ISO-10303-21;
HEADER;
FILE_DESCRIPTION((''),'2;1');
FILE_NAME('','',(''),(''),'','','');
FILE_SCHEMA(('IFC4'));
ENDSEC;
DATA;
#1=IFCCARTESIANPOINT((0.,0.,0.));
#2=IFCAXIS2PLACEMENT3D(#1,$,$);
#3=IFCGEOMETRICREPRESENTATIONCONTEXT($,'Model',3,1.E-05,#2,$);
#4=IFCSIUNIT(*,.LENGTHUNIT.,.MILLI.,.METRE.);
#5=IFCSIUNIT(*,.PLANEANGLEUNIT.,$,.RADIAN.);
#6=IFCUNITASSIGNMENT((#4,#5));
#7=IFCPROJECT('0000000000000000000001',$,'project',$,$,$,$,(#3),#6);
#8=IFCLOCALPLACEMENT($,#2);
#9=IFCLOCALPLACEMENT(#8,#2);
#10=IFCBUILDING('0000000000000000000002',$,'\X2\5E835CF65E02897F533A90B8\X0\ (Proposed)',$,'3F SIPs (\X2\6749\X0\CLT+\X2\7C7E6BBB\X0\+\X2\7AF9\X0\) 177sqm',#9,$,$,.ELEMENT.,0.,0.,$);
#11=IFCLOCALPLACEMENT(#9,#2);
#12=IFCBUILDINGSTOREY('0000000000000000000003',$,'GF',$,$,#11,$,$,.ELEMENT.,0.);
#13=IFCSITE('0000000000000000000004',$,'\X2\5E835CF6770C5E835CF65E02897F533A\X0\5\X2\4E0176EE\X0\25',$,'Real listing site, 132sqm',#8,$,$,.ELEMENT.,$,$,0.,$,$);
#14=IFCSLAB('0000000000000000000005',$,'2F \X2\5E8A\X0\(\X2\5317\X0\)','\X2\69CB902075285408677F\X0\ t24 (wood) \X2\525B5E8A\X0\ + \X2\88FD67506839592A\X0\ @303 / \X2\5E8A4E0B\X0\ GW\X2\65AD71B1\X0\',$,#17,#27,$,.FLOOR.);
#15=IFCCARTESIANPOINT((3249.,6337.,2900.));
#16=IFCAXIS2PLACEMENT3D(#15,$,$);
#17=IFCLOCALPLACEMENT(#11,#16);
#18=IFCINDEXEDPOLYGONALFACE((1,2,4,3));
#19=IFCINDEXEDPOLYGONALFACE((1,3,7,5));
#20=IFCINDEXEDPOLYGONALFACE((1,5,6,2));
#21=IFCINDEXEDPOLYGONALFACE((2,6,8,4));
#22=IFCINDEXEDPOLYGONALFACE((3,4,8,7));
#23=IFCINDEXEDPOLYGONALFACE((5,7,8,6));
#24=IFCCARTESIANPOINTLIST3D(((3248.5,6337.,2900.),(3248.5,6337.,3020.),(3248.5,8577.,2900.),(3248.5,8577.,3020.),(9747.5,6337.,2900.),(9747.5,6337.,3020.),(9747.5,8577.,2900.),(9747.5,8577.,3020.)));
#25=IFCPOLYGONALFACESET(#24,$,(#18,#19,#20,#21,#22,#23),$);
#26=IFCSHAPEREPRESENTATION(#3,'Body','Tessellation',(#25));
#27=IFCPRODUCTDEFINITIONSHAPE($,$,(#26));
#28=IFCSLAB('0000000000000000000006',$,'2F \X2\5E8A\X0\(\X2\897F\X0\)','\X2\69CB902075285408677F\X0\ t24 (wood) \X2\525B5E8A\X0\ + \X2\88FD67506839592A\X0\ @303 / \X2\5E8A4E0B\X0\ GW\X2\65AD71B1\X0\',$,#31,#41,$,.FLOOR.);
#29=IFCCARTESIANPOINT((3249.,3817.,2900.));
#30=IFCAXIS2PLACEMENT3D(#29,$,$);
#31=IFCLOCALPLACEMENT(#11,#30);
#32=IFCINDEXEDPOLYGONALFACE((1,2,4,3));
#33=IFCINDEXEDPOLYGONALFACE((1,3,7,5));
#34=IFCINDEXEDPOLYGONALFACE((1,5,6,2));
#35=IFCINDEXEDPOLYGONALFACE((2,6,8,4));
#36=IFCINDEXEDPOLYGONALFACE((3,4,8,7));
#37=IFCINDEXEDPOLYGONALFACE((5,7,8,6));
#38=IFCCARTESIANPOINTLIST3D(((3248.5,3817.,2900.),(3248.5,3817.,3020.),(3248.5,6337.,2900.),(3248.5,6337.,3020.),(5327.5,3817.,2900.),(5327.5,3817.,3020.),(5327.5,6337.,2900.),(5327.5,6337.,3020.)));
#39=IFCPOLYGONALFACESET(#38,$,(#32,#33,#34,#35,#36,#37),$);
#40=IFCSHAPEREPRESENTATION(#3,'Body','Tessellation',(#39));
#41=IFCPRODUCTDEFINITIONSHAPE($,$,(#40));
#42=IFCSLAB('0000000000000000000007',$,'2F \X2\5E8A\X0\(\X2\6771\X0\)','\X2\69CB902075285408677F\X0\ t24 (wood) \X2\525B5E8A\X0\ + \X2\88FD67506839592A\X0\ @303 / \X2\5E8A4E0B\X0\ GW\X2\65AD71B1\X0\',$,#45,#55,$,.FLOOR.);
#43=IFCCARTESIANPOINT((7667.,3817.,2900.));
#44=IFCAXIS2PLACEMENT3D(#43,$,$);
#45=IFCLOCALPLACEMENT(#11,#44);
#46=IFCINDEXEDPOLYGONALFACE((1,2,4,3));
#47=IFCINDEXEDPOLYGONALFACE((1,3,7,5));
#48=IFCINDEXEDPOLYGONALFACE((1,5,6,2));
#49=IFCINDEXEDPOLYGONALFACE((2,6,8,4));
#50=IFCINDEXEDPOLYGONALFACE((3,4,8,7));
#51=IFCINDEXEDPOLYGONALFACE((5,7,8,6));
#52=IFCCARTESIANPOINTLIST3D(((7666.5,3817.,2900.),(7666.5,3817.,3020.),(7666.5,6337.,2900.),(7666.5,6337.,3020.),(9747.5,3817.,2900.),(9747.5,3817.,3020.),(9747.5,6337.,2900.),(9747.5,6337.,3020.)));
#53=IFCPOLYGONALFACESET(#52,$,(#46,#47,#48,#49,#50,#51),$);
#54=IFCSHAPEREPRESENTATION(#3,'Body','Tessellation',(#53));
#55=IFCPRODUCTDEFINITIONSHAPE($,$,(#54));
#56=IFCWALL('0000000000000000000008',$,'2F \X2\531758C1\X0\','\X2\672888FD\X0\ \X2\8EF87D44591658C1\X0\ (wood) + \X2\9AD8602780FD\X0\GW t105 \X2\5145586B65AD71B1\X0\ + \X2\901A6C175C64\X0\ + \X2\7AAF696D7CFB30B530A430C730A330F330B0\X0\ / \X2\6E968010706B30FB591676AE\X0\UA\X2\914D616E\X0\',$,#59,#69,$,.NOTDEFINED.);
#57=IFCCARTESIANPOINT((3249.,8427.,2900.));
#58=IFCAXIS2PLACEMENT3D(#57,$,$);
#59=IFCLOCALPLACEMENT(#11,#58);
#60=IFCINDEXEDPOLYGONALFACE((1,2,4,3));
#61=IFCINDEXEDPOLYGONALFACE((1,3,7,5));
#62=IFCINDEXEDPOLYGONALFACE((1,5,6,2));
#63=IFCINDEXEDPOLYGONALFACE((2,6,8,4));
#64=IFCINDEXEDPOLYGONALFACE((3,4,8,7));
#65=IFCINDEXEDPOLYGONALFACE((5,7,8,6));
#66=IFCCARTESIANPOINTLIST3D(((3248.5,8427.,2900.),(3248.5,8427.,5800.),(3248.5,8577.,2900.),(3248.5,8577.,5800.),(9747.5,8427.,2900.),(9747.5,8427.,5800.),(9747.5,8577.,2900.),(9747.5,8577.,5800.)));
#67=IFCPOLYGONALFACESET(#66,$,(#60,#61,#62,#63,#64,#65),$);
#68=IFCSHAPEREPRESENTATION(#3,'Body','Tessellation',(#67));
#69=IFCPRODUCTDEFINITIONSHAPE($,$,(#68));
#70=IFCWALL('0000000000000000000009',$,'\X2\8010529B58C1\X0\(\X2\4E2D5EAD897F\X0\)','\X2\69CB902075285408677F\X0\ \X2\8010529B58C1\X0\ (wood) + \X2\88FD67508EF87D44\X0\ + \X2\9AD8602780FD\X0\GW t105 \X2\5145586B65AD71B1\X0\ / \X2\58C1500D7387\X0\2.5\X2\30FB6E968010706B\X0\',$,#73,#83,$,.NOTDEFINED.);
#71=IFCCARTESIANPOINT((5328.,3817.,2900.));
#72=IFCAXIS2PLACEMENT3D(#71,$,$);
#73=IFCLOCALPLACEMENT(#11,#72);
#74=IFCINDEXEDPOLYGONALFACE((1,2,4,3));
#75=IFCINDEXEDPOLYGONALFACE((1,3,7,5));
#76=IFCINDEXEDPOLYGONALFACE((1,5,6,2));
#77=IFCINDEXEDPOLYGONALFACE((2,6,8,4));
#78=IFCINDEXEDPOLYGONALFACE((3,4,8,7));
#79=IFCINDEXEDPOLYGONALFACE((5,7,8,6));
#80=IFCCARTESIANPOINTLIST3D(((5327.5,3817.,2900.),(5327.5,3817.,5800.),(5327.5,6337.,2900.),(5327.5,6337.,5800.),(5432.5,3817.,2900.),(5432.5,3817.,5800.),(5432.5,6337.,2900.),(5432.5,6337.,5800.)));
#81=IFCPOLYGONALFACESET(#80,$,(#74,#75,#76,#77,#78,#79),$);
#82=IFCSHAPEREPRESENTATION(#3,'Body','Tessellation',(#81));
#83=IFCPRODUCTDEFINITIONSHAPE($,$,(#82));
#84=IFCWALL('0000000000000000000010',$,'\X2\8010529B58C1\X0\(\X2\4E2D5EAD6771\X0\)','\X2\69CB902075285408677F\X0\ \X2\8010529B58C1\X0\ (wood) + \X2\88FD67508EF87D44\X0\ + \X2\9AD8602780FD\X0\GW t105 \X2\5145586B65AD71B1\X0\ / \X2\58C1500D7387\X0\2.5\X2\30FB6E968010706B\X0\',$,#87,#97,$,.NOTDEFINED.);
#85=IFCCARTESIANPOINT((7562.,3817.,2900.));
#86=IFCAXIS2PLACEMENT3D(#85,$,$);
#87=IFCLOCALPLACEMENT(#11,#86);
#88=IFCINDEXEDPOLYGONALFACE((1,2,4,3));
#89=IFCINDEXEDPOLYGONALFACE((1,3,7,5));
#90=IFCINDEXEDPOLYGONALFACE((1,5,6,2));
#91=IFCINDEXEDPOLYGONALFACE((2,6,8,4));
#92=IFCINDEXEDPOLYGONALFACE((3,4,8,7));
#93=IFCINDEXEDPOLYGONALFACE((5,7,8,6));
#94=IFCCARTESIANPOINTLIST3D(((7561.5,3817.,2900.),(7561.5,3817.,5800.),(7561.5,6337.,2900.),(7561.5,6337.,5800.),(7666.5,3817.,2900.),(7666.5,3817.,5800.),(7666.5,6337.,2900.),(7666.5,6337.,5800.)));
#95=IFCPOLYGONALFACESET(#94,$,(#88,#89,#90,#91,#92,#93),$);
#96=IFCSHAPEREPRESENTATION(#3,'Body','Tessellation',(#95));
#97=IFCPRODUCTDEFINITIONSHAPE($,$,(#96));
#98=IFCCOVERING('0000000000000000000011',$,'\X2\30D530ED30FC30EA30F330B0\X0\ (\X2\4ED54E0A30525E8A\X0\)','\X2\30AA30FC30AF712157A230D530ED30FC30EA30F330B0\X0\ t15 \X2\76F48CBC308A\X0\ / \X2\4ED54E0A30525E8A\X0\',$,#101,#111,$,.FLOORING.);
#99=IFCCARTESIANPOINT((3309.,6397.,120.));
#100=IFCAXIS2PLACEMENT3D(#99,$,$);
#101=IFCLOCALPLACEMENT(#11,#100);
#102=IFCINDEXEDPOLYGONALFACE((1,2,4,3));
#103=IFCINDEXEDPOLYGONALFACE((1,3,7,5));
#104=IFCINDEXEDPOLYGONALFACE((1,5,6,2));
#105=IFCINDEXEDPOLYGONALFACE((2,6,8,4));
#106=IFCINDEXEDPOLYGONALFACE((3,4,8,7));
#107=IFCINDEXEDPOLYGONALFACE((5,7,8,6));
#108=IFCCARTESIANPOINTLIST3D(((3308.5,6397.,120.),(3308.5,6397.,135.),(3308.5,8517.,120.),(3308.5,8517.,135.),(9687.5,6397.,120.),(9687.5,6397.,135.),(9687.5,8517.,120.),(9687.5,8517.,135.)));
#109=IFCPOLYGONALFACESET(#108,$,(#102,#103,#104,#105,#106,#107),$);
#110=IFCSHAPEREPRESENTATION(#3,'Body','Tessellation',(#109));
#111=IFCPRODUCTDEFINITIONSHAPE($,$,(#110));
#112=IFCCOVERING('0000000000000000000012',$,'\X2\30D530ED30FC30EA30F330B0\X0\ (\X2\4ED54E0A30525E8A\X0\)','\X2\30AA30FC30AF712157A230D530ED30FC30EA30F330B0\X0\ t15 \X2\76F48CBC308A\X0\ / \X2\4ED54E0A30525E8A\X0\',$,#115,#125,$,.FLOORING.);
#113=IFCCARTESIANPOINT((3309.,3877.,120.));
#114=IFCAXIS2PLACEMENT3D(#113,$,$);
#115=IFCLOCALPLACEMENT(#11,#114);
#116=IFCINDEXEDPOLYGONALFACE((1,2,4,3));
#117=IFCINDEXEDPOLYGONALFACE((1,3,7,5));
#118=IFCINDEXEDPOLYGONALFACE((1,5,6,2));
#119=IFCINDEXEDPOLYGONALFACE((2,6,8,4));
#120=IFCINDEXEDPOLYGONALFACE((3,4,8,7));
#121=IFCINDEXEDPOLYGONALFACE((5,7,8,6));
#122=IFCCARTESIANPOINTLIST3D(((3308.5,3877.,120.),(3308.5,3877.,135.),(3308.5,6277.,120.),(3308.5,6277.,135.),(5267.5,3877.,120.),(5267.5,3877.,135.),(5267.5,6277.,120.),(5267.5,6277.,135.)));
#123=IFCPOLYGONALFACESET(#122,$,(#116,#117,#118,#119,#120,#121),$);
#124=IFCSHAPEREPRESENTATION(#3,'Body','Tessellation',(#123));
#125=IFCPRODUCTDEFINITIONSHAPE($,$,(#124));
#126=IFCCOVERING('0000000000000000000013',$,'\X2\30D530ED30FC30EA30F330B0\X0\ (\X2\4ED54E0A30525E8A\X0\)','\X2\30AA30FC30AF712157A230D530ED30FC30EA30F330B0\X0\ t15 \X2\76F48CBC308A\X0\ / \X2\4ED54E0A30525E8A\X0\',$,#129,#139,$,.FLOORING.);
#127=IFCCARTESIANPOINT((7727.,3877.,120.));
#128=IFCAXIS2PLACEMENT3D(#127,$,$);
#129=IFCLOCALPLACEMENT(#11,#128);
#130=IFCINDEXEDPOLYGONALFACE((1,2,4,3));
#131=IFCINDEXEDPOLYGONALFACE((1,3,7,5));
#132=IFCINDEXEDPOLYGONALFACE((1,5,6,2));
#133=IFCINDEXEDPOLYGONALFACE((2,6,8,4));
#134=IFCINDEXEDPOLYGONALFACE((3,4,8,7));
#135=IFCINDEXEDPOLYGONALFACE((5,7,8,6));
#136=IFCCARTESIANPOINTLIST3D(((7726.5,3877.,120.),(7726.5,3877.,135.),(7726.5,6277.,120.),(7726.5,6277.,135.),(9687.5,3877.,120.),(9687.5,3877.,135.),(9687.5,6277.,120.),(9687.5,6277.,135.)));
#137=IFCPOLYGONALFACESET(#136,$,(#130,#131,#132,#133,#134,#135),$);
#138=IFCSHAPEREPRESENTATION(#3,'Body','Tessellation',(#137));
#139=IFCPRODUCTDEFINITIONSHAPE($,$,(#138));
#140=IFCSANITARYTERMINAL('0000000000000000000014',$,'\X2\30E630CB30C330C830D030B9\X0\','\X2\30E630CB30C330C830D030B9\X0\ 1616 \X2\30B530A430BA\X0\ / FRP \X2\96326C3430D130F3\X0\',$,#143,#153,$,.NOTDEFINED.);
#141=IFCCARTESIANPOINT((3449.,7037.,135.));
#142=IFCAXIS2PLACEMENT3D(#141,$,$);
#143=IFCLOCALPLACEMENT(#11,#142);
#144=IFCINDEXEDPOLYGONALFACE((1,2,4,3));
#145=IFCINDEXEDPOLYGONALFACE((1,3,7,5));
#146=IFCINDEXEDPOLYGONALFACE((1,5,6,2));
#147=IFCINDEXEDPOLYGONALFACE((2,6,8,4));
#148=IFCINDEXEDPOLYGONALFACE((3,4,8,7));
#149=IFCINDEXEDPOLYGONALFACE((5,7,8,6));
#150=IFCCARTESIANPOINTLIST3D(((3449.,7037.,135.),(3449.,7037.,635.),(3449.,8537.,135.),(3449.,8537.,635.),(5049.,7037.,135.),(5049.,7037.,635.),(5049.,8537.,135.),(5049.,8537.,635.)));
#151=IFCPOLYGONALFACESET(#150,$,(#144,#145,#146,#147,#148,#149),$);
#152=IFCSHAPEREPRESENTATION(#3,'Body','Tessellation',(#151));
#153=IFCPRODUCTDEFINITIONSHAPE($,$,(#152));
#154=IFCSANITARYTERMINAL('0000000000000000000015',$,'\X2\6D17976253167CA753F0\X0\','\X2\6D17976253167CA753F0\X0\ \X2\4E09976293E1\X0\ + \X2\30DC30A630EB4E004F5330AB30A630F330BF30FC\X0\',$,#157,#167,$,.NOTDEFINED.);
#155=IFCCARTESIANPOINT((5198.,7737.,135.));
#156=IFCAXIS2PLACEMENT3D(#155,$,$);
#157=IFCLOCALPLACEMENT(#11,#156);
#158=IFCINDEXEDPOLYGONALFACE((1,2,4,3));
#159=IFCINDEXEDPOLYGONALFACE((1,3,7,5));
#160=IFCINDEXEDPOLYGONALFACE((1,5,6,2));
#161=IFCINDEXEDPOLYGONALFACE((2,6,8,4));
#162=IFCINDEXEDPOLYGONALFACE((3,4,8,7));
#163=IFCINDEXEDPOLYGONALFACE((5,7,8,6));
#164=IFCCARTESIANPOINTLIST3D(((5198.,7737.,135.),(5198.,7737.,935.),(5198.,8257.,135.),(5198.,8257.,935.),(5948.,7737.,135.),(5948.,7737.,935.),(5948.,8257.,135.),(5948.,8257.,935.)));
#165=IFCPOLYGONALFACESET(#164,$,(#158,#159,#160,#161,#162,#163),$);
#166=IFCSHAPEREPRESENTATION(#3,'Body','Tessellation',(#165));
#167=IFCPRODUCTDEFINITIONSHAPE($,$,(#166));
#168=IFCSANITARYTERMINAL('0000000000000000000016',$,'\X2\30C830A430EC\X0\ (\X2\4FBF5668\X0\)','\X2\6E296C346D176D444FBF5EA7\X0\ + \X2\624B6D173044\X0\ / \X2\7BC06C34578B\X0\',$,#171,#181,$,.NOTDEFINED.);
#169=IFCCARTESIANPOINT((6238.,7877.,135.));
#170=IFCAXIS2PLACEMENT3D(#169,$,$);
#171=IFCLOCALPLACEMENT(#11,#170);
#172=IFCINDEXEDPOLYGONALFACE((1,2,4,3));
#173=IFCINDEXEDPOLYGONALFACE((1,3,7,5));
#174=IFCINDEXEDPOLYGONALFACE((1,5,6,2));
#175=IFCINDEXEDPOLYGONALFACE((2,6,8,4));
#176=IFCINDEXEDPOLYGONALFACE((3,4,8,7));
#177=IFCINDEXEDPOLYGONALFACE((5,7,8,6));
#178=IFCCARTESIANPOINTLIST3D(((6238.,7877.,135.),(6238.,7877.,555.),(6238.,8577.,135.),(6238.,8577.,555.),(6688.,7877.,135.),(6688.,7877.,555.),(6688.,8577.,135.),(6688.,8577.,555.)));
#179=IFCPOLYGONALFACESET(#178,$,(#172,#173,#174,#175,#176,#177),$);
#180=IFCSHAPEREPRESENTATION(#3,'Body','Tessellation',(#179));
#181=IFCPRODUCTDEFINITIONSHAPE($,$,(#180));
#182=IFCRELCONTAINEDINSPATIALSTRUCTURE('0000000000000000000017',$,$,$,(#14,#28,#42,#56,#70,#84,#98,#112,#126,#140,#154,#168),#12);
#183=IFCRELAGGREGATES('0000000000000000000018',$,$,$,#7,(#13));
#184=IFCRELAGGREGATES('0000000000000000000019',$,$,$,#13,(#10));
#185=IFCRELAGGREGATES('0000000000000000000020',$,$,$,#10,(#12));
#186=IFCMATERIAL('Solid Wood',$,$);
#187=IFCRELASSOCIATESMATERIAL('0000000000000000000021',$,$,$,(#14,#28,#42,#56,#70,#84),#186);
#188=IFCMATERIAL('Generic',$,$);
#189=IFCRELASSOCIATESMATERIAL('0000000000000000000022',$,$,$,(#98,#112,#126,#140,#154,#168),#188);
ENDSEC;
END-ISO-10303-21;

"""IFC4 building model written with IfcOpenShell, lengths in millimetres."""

from ifc_helpers import new_model, si_unit, frame, frame_2d, origin, place, context, project, spatial, rectangle, extrude, material, element, save


model = new_model("IFC4")

# Units and contexts
model_context = context("Model", 3, precision=1e-05, world=origin())
ifc_project = project(units=[si_unit("LENGTHUNIT", "METRE", prefix="MILLI"), si_unit("PLANEANGLEUNIT", "RADIAN")], contexts=[model_context])

# Site, building, storey
site_placement = place(None, origin())
site = spatial("IfcSite", under=ifc_project, at=site_placement, Name="広島県広島市西区5丁目25", ObjectType="Real listing site, 132sqm", CompositionType="ELEMENT", RefElevation=0.0)
building_placement = place(site_placement, origin())
building = spatial("IfcBuilding", under=site, at=building_placement, Name="広島市西区邸 (Proposed)", ObjectType="3F SIPs (杉CLT+籾殻+竹) 177sqm", CompositionType="ELEMENT", ElevationOfRefHeight=0.0, ElevationOfTerrain=0.0)
storey_placement = place(building_placement, origin())
storey = spatial("IfcBuildingStorey", under=building, at=storey_placement, Name="GF", CompositionType="ELEMENT", Elevation=0.0)

# Slabs
ifc_material_1 = material(Name="Solid Wood")
slab_1_placement = place(storey_placement, frame((3249.0, 6337.0, 2900.0)))
element("IfcSlab", 1, at=slab_1_placement, inside=storey, material=ifc_material_1, Name="2F 床(北)", Description="構造用合板 t24 (wood) 剛床 + 製材根太 @303 / 床下 GW断熱", PredefinedType="FLOOR", context=model_context, shape_type="SweptSolid", body=[
    extrude(rectangle(XDim=6499.0, YDim=2240.0, at=frame_2d((3249.0, 1120.0))), frame((3249.0, 6337.0, 2900.0)), (0.0, 0.0, 1.0), 120.0),
])
slab_2_placement = place(storey_placement, frame((3249.0, 3817.0, 2900.0)))
element("IfcSlab", 2, at=slab_2_placement, inside=storey, material=ifc_material_1, Name="2F 床(西)", Description="構造用合板 t24 (wood) 剛床 + 製材根太 @303 / 床下 GW断熱", PredefinedType="FLOOR", context=model_context, shape_type="SweptSolid", body=[
    extrude(rectangle(XDim=2079.0, YDim=2520.0, at=frame_2d((1039.0, 1260.0))), frame((3249.0, 3817.0, 2900.0)), (0.0, 0.0, 1.0), 120.0),
])
slab_3_placement = place(storey_placement, frame((7667.0, 3817.0, 2900.0)))
element("IfcSlab", 3, at=slab_3_placement, inside=storey, material=ifc_material_1, Name="2F 床(東)", Description="構造用合板 t24 (wood) 剛床 + 製材根太 @303 / 床下 GW断熱", PredefinedType="FLOOR", context=model_context, shape_type="SweptSolid", body=[
    extrude(rectangle(XDim=2081.0, YDim=2520.0, at=frame_2d((1040.0, 1260.0))), frame((7667.0, 3817.0, 2900.0)), (0.0, 0.0, 1.0), 120.0),
])

# Wall
wall_1_placement = place(storey_placement, frame((3249.0, 8427.0, 2900.0)))
element("IfcWall", 4, at=wall_1_placement, inside=storey, material=ifc_material_1, Name="2F 北壁", Description="木製 軸組外壁 (wood) + 高性能GW t105 充填断熱 + 通気層 + 窯業系サイディング / 準耐火・外皮UA配慮", PredefinedType="NOTDEFINED", context=model_context, shape_type="SweptSolid", body=[
    extrude(rectangle(XDim=6499.0, YDim=150.0, at=frame_2d((3249.0, 75.0))), frame((3249.0, 8427.0, 2900.0)), (0.0, 0.0, 1.0), 2900.0),
])

# Walls
wall_2_placement = place(storey_placement, frame((5328.0, 3817.0, 2900.0)))
element("IfcWall", 5, at=wall_2_placement, inside=storey, material=ifc_material_1, Name="耐力壁(中庭西)", Description="構造用合板 耐力壁 (wood) + 製材軸組 + 高性能GW t105 充填断熱 / 壁倍率2.5・準耐火", PredefinedType="NOTDEFINED", context=model_context, shape_type="SweptSolid", body=[
    extrude(rectangle(XDim=105.0, YDim=2520.0, at=frame_2d((52.0, 1260.0))), frame((5328.0, 3817.0, 2900.0)), (0.0, 0.0, 1.0), 2900.0),
])
wall_3_placement = place(storey_placement, frame((7562.0, 3817.0, 2900.0)))
element("IfcWall", 6, at=wall_3_placement, inside=storey, material=ifc_material_1, Name="耐力壁(中庭東)", Description="構造用合板 耐力壁 (wood) + 製材軸組 + 高性能GW t105 充填断熱 / 壁倍率2.5・準耐火", PredefinedType="NOTDEFINED", context=model_context, shape_type="SweptSolid", body=[
    extrude(rectangle(XDim=105.0, YDim=2520.0, at=frame_2d((52.0, 1260.0))), frame((7562.0, 3817.0, 2900.0)), (0.0, 0.0, 1.0), 2900.0),
])

# Coverings
ifc_material_2 = material(Name="Generic")
covering_1_placement = place(storey_placement, frame((3309.0, 6397.0, 120.0)))
element("IfcCovering", 7, at=covering_1_placement, inside=storey, material=ifc_material_2, Name="フローリング (仕上げ床)", Description="オーク無垢フローリング t15 直貼り / 仕上げ床", PredefinedType="FLOORING", context=model_context, shape_type="SweptSolid", body=[
    extrude(rectangle(XDim=6379.0, YDim=2120.0, at=frame_2d((3189.0, 1060.0))), frame((3309.0, 6397.0, 120.0)), (0.0, 0.0, 1.0), 15.0),
])
covering_2_placement = place(storey_placement, frame((3309.0, 3877.0, 120.0)))
element("IfcCovering", 8, at=covering_2_placement, inside=storey, material=ifc_material_2, Name="フローリング (仕上げ床)", Description="オーク無垢フローリング t15 直貼り / 仕上げ床", PredefinedType="FLOORING", context=model_context, shape_type="SweptSolid", body=[
    extrude(rectangle(XDim=1959.0, YDim=2400.0, at=frame_2d((979.0, 1200.0))), frame((3309.0, 3877.0, 120.0)), (0.0, 0.0, 1.0), 15.0),
])
covering_3_placement = place(storey_placement, frame((7727.0, 3877.0, 120.0)))
element("IfcCovering", 9, at=covering_3_placement, inside=storey, material=ifc_material_2, Name="フローリング (仕上げ床)", Description="オーク無垢フローリング t15 直貼り / 仕上げ床", PredefinedType="FLOORING", context=model_context, shape_type="SweptSolid", body=[
    extrude(rectangle(XDim=1961.0, YDim=2400.0, at=frame_2d((980.0, 1200.0))), frame((7727.0, 3877.0, 120.0)), (0.0, 0.0, 1.0), 15.0),
])

# Sanitary terminals
sanitary_terminal_1_placement = place(storey_placement, frame((3449.0, 7037.0, 135.0)))
element("IfcSanitaryTerminal", 10, at=sanitary_terminal_1_placement, inside=storey, material=ifc_material_2, Name="ユニットバス", Description="ユニットバス 1616 サイズ / FRP 防水パン", PredefinedType="NOTDEFINED", context=model_context, shape_type="SweptSolid", body=[
    extrude(rectangle(XDim=1600.0, YDim=1500.0, at=frame_2d((800.0, 750.0))), frame((3449.0, 7037.0, 135.0)), (0.0, 0.0, 1.0), 500.0),
])
sanitary_terminal_2_placement = place(storey_placement, frame((5198.0, 7737.0, 135.0)))
element("IfcSanitaryTerminal", 11, at=sanitary_terminal_2_placement, inside=storey, material=ifc_material_2, Name="洗面化粧台", Description="洗面化粧台 三面鏡 + ボウル一体カウンター", PredefinedType="NOTDEFINED", context=model_context, shape_type="SweptSolid", body=[
    extrude(rectangle(XDim=750.0, YDim=520.0, at=frame_2d((375.0, 260.0))), frame((5198.0, 7737.0, 135.0)), (0.0, 0.0, 1.0), 800.0),
])
sanitary_terminal_3_placement = place(storey_placement, frame((6238.0, 7877.0, 135.0)))
element("IfcSanitaryTerminal", 12, at=sanitary_terminal_3_placement, inside=storey, material=ifc_material_2, Name="トイレ (便器)", Description="温水洗浄便座 + 手洗い / 節水型", PredefinedType="NOTDEFINED", context=model_context, shape_type="SweptSolid", body=[
    extrude(rectangle(XDim=450.0, YDim=700.0, at=frame_2d((225.0, 350.0))), frame((6238.0, 7877.0, 135.0)), (0.0, 0.0, 1.0), 420.0),
])

save(model, "model.ifc")
